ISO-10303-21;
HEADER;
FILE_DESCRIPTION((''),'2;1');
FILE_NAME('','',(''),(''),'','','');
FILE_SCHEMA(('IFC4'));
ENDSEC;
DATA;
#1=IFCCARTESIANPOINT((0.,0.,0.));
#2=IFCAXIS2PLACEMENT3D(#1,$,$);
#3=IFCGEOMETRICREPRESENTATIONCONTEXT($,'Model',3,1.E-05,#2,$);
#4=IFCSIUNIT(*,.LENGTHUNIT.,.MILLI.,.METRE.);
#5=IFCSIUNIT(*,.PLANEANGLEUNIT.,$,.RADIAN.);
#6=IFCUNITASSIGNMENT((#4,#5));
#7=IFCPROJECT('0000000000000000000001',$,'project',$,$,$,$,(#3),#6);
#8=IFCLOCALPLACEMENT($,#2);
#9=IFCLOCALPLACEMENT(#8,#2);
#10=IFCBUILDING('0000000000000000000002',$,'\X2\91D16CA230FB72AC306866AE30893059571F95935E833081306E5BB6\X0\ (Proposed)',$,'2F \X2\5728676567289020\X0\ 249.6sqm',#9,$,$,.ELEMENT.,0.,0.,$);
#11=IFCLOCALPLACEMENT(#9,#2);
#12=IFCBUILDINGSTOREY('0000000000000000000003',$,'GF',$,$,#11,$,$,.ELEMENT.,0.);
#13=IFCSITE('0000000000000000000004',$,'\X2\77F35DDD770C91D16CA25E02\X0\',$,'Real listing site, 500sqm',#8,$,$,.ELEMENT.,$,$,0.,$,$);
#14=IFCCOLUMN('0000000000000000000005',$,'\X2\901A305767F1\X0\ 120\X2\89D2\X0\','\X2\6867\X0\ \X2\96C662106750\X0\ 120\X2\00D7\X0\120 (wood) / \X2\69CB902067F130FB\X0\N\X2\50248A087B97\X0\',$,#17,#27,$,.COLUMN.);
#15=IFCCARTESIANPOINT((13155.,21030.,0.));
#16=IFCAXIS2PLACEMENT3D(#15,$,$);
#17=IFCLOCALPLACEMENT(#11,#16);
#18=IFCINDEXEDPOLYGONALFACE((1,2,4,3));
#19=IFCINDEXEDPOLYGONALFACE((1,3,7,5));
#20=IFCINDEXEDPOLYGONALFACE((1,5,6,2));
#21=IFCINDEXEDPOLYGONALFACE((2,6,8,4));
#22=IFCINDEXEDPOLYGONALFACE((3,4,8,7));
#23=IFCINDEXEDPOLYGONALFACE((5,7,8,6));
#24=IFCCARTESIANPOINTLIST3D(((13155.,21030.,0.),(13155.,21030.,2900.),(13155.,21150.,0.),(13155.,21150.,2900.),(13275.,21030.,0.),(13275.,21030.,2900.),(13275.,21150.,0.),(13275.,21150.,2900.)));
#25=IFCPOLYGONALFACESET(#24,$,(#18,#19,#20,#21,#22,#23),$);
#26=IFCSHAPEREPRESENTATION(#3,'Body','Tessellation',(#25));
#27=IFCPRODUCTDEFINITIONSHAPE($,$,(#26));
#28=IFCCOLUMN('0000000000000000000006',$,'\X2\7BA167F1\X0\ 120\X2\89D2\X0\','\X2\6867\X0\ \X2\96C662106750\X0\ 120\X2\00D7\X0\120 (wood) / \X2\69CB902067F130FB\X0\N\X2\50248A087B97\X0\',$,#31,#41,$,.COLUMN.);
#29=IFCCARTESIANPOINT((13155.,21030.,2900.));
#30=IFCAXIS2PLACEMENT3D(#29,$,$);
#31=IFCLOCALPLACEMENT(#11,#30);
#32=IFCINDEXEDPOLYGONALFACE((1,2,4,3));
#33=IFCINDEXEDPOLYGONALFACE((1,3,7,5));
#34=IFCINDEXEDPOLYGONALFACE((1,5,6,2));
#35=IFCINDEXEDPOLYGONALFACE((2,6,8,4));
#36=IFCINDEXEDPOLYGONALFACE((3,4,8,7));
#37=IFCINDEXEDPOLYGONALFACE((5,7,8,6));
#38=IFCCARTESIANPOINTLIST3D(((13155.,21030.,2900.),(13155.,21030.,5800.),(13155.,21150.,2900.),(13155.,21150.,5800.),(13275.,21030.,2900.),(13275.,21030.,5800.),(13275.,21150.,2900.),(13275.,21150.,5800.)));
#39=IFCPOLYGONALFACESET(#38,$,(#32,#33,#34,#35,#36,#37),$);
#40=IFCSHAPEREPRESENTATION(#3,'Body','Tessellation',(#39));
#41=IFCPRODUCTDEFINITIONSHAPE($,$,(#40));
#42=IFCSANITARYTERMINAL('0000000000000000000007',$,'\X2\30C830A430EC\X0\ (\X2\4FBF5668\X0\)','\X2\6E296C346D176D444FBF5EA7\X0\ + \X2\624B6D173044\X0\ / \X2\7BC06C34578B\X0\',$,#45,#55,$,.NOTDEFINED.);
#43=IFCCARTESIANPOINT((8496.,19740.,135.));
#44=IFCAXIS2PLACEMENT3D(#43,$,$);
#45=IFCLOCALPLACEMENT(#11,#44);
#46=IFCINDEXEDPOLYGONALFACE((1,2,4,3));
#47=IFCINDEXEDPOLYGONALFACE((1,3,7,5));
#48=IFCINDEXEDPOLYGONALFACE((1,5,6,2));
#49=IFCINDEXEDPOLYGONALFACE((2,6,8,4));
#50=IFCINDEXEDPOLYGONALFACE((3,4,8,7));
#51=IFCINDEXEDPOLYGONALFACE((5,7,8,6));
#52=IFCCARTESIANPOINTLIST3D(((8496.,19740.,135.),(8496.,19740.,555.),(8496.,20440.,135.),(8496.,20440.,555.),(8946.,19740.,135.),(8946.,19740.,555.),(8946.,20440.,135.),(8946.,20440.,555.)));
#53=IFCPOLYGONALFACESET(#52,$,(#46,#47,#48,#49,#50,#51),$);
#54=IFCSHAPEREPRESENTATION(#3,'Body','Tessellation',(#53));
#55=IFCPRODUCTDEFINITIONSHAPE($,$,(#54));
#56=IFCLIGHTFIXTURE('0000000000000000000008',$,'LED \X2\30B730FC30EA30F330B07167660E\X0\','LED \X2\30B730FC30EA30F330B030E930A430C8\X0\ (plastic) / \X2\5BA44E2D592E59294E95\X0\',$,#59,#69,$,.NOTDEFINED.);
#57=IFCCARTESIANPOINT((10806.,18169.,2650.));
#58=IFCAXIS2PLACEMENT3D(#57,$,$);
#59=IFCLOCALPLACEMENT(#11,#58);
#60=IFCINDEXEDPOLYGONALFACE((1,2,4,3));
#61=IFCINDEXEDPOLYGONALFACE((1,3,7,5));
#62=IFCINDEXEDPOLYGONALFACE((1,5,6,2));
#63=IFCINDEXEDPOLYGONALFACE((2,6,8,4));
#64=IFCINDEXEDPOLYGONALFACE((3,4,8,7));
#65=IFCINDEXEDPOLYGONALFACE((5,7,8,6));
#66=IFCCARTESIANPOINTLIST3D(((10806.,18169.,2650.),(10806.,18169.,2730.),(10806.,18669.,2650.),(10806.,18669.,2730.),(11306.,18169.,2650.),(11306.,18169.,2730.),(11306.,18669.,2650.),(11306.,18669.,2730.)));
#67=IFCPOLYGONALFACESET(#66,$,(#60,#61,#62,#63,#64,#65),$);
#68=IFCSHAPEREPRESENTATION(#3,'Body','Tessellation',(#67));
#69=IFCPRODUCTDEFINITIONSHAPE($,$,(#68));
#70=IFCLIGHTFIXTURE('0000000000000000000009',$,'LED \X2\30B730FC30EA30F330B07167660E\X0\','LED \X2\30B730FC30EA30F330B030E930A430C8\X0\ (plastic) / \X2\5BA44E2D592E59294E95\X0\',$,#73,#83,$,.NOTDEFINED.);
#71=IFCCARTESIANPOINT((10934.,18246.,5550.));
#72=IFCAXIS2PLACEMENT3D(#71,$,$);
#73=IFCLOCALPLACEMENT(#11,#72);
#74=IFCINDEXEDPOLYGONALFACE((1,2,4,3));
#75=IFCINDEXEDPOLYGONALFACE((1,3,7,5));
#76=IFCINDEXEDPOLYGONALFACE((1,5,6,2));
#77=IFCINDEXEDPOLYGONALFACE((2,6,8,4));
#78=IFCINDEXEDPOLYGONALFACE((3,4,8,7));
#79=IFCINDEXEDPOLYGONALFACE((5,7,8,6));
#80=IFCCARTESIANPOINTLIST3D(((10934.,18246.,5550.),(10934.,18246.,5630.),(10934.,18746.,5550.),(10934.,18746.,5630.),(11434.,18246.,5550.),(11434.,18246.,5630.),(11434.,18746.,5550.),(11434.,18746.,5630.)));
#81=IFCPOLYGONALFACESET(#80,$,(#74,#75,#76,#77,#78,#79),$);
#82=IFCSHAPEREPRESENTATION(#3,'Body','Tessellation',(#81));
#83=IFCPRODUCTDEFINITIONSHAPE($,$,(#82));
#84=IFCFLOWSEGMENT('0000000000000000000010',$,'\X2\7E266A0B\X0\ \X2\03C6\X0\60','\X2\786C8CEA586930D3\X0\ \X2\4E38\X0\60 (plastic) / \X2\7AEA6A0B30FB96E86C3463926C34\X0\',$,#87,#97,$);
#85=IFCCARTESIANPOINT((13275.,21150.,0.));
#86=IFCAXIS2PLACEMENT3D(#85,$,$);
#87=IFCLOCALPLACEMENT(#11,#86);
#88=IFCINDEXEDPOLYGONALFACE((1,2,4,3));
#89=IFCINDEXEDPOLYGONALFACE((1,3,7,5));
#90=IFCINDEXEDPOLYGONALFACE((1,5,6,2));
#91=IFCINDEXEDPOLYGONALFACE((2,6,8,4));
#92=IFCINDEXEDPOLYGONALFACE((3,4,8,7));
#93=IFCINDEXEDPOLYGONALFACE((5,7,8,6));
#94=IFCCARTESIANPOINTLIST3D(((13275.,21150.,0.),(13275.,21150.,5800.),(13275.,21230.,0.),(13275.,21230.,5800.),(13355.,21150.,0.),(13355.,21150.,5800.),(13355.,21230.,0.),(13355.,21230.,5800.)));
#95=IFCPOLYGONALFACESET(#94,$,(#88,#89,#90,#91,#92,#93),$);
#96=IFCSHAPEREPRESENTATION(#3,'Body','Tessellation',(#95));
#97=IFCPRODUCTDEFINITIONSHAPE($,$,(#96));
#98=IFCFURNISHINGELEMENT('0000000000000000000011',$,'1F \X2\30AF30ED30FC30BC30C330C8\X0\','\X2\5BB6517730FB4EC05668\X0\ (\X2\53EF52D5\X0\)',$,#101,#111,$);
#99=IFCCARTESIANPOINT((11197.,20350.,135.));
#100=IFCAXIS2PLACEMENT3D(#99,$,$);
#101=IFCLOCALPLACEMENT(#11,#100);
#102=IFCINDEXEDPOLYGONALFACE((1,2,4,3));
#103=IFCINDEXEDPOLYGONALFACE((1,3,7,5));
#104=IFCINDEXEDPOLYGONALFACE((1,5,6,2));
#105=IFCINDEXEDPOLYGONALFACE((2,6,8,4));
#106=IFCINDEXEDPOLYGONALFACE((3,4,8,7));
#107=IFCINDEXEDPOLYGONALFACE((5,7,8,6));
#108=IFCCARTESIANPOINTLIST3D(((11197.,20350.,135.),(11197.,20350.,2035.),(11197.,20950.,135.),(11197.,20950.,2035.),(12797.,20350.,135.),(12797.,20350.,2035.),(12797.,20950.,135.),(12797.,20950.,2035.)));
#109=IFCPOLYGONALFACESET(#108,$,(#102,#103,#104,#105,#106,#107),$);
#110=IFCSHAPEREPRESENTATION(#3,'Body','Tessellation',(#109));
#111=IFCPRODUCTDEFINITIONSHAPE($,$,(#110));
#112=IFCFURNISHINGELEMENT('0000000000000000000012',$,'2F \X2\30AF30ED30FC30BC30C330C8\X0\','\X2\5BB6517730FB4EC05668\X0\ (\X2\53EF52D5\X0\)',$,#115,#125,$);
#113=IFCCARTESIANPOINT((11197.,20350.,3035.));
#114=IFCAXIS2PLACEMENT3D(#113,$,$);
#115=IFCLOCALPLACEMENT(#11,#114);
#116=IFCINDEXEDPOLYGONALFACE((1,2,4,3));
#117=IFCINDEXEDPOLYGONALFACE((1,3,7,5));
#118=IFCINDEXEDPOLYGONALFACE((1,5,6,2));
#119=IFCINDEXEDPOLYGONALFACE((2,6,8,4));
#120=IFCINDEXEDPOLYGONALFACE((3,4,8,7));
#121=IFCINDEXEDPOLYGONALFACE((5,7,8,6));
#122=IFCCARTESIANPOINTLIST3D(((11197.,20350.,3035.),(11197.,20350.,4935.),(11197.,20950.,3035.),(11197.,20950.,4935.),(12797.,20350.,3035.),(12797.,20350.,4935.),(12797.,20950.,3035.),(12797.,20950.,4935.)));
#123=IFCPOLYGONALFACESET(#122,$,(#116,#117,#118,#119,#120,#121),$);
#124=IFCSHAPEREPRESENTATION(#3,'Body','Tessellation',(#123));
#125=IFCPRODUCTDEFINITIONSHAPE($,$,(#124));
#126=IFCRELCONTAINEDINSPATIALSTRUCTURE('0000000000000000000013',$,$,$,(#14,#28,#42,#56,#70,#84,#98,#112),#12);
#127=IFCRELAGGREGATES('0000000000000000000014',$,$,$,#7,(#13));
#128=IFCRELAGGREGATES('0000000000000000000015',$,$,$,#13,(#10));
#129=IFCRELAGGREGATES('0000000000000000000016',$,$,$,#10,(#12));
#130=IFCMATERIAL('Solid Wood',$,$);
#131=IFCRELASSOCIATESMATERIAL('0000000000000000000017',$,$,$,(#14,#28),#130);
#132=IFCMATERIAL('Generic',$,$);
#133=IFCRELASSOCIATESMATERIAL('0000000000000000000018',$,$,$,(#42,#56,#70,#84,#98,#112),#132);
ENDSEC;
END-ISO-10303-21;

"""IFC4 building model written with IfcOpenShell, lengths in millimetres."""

from ifc_helpers import new_model, si_unit, frame, frame_2d, origin, place, context, project, spatial, rectangle, extrude, material, element, save


model = new_model("IFC4")

# Units and contexts
model_context = context("Model", 3, precision=1e-05, world=origin())
ifc_project = project(units=[si_unit("LENGTHUNIT", "METRE", prefix="MILLI"), si_unit("PLANEANGLEUNIT", "RADIAN")], contexts=[model_context])

# Site, building, storey
site_placement = place(None, origin())
site = spatial("IfcSite", under=ifc_project, at=site_placement, Name="石川県金沢市", ObjectType="Real listing site, 500sqm", CompositionType="ELEMENT", RefElevation=0.0)
building_placement = place(site_placement, origin())
building = spatial("IfcBuilding", under=site, at=building_placement, Name="金沢・犬と暮らす土間広めの家 (Proposed)", ObjectType="2F 在来木造 249.6sqm", CompositionType="ELEMENT", ElevationOfRefHeight=0.0, ElevationOfTerrain=0.0)
storey_placement = place(building_placement, origin())
storey = spatial("IfcBuildingStorey", under=building, at=storey_placement, Name="GF", CompositionType="ELEMENT", Elevation=0.0)

# Columns
ifc_material_1 = material(Name="Solid Wood")
column_1_placement = place(storey_placement, frame((13155.0, 21030.0, 0.0)))
element("IfcColumn", 1, at=column_1_placement, inside=storey, material=ifc_material_1, Name="通し柱 120角", Description="桧 集成材 120×120 (wood) / 構造柱・N値計算", PredefinedType="COLUMN", context=model_context, shape_type="SweptSolid", body=[
    extrude(rectangle(XDim=120.0, YDim=120.0, at=frame_2d((60.0, 60.0))), frame((13155.0, 21030.0, 0.0)), (0.0, 0.0, 1.0), 2900.0),
])
column_2_placement = place(storey_placement, frame((13155.0, 21030.0, 2900.0)))
element("IfcColumn", 2, at=column_2_placement, inside=storey, material=ifc_material_1, Name="管柱 120角", Description="桧 集成材 120×120 (wood) / 構造柱・N値計算", PredefinedType="COLUMN", context=model_context, shape_type="SweptSolid", body=[
    extrude(rectangle(XDim=120.0, YDim=120.0, at=frame_2d((60.0, 60.0))), frame((13155.0, 21030.0, 2900.0)), (0.0, 0.0, 1.0), 2900.0),
])

# Sanitary terminal
ifc_material_2 = material(Name="Generic")
sanitary_terminal_placement = place(storey_placement, frame((8496.0, 19740.0, 135.0)))
element("IfcSanitaryTerminal", 3, at=sanitary_terminal_placement, inside=storey, material=ifc_material_2, Name="トイレ (便器)", Description="温水洗浄便座 + 手洗い / 節水型", PredefinedType="NOTDEFINED", context=model_context, shape_type="SweptSolid", body=[
    extrude(rectangle(XDim=450.0, YDim=700.0, at=frame_2d((225.0, 350.0))), frame((8496.0, 19740.0, 135.0)), (0.0, 0.0, 1.0), 420.0),
])

# Light fixtures
light_fixture_1_placement = place(storey_placement, frame((10806.0, 18169.0, 2650.0)))
element("IfcLightFixture", 4, at=light_fixture_1_placement, inside=storey, material=ifc_material_2, Name="LED シーリング照明", Description="LED シーリングライト (plastic) / 室中央天井", PredefinedType="NOTDEFINED", context=model_context, shape_type="SweptSolid", body=[
    extrude(rectangle(XDim=500.0, YDim=500.0, at=frame_2d((250.0, 250.0))), frame((10806.0, 18169.0, 2650.0)), (0.0, 0.0, 1.0), 80.0),
])
light_fixture_2_placement = place(storey_placement, frame((10934.0, 18246.0, 5550.0)))
element("IfcLightFixture", 5, at=light_fixture_2_placement, inside=storey, material=ifc_material_2, Name="LED シーリング照明", Description="LED シーリングライト (plastic) / 室中央天井", PredefinedType="NOTDEFINED", context=model_context, shape_type="SweptSolid", body=[
    extrude(rectangle(XDim=500.0, YDim=500.0, at=frame_2d((250.0, 250.0))), frame((10934.0, 18246.0, 5550.0)), (0.0, 0.0, 1.0), 80.0),
])

# Flow segment
flow_segment_placement = place(storey_placement, frame((13275.0, 21150.0, 0.0)))
element("IfcFlowSegment", 6, at=flow_segment_placement, inside=storey, material=ifc_material_2, Name="縦樋 φ60", Description="硬質塩ビ 丸60 (plastic) / 竪樋・雨水排水", context=model_context, shape_type="SweptSolid", body=[
    extrude(rectangle(XDim=80.0, YDim=80.0, at=frame_2d((40.0, 40.0))), frame((13275.0, 21150.0, 0.0)), (0.0, 0.0, 1.0), 5800.0),
])

# Furnishing elements
furnishing_1_placement = place(storey_placement, frame((11197.0, 20350.0, 135.0)))
element("IfcFurnishingElement", 7, at=furnishing_1_placement, inside=storey, material=ifc_material_2, Name="1F クローゼット", Description="家具・什器 (可動)", context=model_context, shape_type="SweptSolid", body=[
    extrude(rectangle(XDim=1600.0, YDim=600.0, at=frame_2d((800.0, 300.0))), frame((11197.0, 20350.0, 135.0)), (0.0, 0.0, 1.0), 1900.0),
])
furnishing_2_placement = place(storey_placement, frame((11197.0, 20350.0, 3035.0)))
element("IfcFurnishingElement", 8, at=furnishing_2_placement, inside=storey, material=ifc_material_2, Name="2F クローゼット", Description="家具・什器 (可動)", context=model_context, shape_type="SweptSolid", body=[
    extrude(rectangle(XDim=1600.0, YDim=600.0, at=frame_2d((800.0, 300.0))), frame((11197.0, 20350.0, 3035.0)), (0.0, 0.0, 1.0), 1900.0),
])

save(model, "model.ifc")
